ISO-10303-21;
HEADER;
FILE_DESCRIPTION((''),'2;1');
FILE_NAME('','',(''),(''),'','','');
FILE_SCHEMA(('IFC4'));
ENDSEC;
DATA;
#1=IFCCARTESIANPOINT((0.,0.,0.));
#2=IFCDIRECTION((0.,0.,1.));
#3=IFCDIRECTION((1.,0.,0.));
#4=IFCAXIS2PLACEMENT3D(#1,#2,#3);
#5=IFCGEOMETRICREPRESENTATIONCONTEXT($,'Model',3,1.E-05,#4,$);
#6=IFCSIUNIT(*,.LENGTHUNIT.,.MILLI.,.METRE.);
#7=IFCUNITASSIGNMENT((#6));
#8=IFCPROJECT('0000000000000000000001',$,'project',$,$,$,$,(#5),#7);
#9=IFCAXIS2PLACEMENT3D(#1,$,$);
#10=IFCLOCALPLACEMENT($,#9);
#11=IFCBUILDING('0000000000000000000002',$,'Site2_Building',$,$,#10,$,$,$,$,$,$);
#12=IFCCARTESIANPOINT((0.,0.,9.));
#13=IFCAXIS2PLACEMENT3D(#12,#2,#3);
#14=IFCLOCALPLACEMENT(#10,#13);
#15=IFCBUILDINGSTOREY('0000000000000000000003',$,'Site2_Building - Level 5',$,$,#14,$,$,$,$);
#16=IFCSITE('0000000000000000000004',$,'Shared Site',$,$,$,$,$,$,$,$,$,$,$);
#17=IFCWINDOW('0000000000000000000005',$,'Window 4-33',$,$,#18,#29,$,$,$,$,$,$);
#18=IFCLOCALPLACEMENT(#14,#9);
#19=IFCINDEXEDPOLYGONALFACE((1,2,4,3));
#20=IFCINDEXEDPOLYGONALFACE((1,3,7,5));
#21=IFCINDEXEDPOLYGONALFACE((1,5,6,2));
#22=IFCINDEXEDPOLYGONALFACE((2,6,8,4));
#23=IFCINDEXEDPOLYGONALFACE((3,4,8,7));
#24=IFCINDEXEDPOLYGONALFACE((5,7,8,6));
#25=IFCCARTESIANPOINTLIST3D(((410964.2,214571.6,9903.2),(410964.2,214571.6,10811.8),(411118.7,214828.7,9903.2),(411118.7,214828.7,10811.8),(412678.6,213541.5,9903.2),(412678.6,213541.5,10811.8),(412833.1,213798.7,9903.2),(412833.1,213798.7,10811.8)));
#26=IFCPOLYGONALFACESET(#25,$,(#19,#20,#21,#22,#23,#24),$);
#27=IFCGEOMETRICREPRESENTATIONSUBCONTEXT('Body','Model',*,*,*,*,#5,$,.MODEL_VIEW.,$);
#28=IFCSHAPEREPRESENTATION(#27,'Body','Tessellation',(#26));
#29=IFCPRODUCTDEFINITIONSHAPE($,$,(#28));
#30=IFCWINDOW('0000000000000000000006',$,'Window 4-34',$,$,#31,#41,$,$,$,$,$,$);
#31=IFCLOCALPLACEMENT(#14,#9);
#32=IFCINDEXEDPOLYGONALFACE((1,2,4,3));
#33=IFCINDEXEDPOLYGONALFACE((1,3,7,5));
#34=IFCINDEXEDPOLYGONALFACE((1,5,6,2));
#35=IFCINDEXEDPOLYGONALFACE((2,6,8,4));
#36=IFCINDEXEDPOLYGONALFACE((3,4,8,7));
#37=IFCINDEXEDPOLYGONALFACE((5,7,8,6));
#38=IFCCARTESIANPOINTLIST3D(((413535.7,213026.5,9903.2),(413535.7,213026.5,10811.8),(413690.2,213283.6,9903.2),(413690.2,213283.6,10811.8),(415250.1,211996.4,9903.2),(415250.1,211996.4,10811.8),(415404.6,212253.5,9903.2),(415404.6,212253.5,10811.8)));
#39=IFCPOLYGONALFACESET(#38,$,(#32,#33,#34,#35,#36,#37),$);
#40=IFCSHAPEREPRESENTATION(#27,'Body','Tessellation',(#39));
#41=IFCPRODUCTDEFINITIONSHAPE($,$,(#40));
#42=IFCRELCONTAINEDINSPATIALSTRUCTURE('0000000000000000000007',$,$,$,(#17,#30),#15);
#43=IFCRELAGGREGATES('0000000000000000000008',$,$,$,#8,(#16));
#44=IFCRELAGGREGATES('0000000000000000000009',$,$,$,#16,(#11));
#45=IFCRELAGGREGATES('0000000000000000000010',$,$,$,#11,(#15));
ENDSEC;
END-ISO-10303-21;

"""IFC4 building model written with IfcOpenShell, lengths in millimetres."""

from ifc_helpers import new_model, si_unit, frame, origin, origin_with_axes, place, context, subcontext, project, spatial, indexed_curve, outline, extrude, element, save


model = new_model("IFC4")

# Units and contexts
model_context = context("Model", 3, precision=1e-05, world=origin_with_axes())
body_context = subcontext(model_context, "Body", "Model", "MODEL_VIEW")
ifc_project = project(units=[si_unit("LENGTHUNIT", "METRE", prefix="MILLI")], contexts=[model_context])

# Site, building, storey
site = spatial("IfcSite", under=ifc_project, Name="Shared Site")
building_placement = place(None, origin())
building = spatial("IfcBuilding", under=site, at=building_placement, Name="Site2_Building")
storey_placement = place(building_placement, frame((0.0, 0.0, 9.0), z_axis=(0.0, 0.0, 1.0), x_axis=(1.0, 0.0, 0.0)))
storey = spatial("IfcBuildingStorey", under=building, at=storey_placement, Name="Site2_Building - Level 5")

# Windows
for number, where, z_axis, x_axis, name in (
    (1, (410964.2, 214571.6, 9903.2), (0.0, 0.0, 1.0), (0.857167, -0.515038, 0.0), "Window 4-33"),
    (2, (413535.7, 213026.5, 9903.2), (0.0, 0.0, 1.0), (0.857167, -0.515038, 0.0), "Window 4-34"),
):
    element("IfcWindow", number, at=place(storey_placement, frame(where, z_axis=z_axis, x_axis=x_axis)), inside=storey, Name=name, context=body_context, shape_type="SweptSolid", body=[
        extrude(outline(indexed_curve([(0.0, 0.0), (0.0, 300.0), (2000.0, 300.0), (2000.0, 0.0), (0.0, 0.0)], self_intersect=False)), origin_with_axes(), (0.0, 0.0, 1.0), 908.6),
    ])

save(model, "model.ifc")
